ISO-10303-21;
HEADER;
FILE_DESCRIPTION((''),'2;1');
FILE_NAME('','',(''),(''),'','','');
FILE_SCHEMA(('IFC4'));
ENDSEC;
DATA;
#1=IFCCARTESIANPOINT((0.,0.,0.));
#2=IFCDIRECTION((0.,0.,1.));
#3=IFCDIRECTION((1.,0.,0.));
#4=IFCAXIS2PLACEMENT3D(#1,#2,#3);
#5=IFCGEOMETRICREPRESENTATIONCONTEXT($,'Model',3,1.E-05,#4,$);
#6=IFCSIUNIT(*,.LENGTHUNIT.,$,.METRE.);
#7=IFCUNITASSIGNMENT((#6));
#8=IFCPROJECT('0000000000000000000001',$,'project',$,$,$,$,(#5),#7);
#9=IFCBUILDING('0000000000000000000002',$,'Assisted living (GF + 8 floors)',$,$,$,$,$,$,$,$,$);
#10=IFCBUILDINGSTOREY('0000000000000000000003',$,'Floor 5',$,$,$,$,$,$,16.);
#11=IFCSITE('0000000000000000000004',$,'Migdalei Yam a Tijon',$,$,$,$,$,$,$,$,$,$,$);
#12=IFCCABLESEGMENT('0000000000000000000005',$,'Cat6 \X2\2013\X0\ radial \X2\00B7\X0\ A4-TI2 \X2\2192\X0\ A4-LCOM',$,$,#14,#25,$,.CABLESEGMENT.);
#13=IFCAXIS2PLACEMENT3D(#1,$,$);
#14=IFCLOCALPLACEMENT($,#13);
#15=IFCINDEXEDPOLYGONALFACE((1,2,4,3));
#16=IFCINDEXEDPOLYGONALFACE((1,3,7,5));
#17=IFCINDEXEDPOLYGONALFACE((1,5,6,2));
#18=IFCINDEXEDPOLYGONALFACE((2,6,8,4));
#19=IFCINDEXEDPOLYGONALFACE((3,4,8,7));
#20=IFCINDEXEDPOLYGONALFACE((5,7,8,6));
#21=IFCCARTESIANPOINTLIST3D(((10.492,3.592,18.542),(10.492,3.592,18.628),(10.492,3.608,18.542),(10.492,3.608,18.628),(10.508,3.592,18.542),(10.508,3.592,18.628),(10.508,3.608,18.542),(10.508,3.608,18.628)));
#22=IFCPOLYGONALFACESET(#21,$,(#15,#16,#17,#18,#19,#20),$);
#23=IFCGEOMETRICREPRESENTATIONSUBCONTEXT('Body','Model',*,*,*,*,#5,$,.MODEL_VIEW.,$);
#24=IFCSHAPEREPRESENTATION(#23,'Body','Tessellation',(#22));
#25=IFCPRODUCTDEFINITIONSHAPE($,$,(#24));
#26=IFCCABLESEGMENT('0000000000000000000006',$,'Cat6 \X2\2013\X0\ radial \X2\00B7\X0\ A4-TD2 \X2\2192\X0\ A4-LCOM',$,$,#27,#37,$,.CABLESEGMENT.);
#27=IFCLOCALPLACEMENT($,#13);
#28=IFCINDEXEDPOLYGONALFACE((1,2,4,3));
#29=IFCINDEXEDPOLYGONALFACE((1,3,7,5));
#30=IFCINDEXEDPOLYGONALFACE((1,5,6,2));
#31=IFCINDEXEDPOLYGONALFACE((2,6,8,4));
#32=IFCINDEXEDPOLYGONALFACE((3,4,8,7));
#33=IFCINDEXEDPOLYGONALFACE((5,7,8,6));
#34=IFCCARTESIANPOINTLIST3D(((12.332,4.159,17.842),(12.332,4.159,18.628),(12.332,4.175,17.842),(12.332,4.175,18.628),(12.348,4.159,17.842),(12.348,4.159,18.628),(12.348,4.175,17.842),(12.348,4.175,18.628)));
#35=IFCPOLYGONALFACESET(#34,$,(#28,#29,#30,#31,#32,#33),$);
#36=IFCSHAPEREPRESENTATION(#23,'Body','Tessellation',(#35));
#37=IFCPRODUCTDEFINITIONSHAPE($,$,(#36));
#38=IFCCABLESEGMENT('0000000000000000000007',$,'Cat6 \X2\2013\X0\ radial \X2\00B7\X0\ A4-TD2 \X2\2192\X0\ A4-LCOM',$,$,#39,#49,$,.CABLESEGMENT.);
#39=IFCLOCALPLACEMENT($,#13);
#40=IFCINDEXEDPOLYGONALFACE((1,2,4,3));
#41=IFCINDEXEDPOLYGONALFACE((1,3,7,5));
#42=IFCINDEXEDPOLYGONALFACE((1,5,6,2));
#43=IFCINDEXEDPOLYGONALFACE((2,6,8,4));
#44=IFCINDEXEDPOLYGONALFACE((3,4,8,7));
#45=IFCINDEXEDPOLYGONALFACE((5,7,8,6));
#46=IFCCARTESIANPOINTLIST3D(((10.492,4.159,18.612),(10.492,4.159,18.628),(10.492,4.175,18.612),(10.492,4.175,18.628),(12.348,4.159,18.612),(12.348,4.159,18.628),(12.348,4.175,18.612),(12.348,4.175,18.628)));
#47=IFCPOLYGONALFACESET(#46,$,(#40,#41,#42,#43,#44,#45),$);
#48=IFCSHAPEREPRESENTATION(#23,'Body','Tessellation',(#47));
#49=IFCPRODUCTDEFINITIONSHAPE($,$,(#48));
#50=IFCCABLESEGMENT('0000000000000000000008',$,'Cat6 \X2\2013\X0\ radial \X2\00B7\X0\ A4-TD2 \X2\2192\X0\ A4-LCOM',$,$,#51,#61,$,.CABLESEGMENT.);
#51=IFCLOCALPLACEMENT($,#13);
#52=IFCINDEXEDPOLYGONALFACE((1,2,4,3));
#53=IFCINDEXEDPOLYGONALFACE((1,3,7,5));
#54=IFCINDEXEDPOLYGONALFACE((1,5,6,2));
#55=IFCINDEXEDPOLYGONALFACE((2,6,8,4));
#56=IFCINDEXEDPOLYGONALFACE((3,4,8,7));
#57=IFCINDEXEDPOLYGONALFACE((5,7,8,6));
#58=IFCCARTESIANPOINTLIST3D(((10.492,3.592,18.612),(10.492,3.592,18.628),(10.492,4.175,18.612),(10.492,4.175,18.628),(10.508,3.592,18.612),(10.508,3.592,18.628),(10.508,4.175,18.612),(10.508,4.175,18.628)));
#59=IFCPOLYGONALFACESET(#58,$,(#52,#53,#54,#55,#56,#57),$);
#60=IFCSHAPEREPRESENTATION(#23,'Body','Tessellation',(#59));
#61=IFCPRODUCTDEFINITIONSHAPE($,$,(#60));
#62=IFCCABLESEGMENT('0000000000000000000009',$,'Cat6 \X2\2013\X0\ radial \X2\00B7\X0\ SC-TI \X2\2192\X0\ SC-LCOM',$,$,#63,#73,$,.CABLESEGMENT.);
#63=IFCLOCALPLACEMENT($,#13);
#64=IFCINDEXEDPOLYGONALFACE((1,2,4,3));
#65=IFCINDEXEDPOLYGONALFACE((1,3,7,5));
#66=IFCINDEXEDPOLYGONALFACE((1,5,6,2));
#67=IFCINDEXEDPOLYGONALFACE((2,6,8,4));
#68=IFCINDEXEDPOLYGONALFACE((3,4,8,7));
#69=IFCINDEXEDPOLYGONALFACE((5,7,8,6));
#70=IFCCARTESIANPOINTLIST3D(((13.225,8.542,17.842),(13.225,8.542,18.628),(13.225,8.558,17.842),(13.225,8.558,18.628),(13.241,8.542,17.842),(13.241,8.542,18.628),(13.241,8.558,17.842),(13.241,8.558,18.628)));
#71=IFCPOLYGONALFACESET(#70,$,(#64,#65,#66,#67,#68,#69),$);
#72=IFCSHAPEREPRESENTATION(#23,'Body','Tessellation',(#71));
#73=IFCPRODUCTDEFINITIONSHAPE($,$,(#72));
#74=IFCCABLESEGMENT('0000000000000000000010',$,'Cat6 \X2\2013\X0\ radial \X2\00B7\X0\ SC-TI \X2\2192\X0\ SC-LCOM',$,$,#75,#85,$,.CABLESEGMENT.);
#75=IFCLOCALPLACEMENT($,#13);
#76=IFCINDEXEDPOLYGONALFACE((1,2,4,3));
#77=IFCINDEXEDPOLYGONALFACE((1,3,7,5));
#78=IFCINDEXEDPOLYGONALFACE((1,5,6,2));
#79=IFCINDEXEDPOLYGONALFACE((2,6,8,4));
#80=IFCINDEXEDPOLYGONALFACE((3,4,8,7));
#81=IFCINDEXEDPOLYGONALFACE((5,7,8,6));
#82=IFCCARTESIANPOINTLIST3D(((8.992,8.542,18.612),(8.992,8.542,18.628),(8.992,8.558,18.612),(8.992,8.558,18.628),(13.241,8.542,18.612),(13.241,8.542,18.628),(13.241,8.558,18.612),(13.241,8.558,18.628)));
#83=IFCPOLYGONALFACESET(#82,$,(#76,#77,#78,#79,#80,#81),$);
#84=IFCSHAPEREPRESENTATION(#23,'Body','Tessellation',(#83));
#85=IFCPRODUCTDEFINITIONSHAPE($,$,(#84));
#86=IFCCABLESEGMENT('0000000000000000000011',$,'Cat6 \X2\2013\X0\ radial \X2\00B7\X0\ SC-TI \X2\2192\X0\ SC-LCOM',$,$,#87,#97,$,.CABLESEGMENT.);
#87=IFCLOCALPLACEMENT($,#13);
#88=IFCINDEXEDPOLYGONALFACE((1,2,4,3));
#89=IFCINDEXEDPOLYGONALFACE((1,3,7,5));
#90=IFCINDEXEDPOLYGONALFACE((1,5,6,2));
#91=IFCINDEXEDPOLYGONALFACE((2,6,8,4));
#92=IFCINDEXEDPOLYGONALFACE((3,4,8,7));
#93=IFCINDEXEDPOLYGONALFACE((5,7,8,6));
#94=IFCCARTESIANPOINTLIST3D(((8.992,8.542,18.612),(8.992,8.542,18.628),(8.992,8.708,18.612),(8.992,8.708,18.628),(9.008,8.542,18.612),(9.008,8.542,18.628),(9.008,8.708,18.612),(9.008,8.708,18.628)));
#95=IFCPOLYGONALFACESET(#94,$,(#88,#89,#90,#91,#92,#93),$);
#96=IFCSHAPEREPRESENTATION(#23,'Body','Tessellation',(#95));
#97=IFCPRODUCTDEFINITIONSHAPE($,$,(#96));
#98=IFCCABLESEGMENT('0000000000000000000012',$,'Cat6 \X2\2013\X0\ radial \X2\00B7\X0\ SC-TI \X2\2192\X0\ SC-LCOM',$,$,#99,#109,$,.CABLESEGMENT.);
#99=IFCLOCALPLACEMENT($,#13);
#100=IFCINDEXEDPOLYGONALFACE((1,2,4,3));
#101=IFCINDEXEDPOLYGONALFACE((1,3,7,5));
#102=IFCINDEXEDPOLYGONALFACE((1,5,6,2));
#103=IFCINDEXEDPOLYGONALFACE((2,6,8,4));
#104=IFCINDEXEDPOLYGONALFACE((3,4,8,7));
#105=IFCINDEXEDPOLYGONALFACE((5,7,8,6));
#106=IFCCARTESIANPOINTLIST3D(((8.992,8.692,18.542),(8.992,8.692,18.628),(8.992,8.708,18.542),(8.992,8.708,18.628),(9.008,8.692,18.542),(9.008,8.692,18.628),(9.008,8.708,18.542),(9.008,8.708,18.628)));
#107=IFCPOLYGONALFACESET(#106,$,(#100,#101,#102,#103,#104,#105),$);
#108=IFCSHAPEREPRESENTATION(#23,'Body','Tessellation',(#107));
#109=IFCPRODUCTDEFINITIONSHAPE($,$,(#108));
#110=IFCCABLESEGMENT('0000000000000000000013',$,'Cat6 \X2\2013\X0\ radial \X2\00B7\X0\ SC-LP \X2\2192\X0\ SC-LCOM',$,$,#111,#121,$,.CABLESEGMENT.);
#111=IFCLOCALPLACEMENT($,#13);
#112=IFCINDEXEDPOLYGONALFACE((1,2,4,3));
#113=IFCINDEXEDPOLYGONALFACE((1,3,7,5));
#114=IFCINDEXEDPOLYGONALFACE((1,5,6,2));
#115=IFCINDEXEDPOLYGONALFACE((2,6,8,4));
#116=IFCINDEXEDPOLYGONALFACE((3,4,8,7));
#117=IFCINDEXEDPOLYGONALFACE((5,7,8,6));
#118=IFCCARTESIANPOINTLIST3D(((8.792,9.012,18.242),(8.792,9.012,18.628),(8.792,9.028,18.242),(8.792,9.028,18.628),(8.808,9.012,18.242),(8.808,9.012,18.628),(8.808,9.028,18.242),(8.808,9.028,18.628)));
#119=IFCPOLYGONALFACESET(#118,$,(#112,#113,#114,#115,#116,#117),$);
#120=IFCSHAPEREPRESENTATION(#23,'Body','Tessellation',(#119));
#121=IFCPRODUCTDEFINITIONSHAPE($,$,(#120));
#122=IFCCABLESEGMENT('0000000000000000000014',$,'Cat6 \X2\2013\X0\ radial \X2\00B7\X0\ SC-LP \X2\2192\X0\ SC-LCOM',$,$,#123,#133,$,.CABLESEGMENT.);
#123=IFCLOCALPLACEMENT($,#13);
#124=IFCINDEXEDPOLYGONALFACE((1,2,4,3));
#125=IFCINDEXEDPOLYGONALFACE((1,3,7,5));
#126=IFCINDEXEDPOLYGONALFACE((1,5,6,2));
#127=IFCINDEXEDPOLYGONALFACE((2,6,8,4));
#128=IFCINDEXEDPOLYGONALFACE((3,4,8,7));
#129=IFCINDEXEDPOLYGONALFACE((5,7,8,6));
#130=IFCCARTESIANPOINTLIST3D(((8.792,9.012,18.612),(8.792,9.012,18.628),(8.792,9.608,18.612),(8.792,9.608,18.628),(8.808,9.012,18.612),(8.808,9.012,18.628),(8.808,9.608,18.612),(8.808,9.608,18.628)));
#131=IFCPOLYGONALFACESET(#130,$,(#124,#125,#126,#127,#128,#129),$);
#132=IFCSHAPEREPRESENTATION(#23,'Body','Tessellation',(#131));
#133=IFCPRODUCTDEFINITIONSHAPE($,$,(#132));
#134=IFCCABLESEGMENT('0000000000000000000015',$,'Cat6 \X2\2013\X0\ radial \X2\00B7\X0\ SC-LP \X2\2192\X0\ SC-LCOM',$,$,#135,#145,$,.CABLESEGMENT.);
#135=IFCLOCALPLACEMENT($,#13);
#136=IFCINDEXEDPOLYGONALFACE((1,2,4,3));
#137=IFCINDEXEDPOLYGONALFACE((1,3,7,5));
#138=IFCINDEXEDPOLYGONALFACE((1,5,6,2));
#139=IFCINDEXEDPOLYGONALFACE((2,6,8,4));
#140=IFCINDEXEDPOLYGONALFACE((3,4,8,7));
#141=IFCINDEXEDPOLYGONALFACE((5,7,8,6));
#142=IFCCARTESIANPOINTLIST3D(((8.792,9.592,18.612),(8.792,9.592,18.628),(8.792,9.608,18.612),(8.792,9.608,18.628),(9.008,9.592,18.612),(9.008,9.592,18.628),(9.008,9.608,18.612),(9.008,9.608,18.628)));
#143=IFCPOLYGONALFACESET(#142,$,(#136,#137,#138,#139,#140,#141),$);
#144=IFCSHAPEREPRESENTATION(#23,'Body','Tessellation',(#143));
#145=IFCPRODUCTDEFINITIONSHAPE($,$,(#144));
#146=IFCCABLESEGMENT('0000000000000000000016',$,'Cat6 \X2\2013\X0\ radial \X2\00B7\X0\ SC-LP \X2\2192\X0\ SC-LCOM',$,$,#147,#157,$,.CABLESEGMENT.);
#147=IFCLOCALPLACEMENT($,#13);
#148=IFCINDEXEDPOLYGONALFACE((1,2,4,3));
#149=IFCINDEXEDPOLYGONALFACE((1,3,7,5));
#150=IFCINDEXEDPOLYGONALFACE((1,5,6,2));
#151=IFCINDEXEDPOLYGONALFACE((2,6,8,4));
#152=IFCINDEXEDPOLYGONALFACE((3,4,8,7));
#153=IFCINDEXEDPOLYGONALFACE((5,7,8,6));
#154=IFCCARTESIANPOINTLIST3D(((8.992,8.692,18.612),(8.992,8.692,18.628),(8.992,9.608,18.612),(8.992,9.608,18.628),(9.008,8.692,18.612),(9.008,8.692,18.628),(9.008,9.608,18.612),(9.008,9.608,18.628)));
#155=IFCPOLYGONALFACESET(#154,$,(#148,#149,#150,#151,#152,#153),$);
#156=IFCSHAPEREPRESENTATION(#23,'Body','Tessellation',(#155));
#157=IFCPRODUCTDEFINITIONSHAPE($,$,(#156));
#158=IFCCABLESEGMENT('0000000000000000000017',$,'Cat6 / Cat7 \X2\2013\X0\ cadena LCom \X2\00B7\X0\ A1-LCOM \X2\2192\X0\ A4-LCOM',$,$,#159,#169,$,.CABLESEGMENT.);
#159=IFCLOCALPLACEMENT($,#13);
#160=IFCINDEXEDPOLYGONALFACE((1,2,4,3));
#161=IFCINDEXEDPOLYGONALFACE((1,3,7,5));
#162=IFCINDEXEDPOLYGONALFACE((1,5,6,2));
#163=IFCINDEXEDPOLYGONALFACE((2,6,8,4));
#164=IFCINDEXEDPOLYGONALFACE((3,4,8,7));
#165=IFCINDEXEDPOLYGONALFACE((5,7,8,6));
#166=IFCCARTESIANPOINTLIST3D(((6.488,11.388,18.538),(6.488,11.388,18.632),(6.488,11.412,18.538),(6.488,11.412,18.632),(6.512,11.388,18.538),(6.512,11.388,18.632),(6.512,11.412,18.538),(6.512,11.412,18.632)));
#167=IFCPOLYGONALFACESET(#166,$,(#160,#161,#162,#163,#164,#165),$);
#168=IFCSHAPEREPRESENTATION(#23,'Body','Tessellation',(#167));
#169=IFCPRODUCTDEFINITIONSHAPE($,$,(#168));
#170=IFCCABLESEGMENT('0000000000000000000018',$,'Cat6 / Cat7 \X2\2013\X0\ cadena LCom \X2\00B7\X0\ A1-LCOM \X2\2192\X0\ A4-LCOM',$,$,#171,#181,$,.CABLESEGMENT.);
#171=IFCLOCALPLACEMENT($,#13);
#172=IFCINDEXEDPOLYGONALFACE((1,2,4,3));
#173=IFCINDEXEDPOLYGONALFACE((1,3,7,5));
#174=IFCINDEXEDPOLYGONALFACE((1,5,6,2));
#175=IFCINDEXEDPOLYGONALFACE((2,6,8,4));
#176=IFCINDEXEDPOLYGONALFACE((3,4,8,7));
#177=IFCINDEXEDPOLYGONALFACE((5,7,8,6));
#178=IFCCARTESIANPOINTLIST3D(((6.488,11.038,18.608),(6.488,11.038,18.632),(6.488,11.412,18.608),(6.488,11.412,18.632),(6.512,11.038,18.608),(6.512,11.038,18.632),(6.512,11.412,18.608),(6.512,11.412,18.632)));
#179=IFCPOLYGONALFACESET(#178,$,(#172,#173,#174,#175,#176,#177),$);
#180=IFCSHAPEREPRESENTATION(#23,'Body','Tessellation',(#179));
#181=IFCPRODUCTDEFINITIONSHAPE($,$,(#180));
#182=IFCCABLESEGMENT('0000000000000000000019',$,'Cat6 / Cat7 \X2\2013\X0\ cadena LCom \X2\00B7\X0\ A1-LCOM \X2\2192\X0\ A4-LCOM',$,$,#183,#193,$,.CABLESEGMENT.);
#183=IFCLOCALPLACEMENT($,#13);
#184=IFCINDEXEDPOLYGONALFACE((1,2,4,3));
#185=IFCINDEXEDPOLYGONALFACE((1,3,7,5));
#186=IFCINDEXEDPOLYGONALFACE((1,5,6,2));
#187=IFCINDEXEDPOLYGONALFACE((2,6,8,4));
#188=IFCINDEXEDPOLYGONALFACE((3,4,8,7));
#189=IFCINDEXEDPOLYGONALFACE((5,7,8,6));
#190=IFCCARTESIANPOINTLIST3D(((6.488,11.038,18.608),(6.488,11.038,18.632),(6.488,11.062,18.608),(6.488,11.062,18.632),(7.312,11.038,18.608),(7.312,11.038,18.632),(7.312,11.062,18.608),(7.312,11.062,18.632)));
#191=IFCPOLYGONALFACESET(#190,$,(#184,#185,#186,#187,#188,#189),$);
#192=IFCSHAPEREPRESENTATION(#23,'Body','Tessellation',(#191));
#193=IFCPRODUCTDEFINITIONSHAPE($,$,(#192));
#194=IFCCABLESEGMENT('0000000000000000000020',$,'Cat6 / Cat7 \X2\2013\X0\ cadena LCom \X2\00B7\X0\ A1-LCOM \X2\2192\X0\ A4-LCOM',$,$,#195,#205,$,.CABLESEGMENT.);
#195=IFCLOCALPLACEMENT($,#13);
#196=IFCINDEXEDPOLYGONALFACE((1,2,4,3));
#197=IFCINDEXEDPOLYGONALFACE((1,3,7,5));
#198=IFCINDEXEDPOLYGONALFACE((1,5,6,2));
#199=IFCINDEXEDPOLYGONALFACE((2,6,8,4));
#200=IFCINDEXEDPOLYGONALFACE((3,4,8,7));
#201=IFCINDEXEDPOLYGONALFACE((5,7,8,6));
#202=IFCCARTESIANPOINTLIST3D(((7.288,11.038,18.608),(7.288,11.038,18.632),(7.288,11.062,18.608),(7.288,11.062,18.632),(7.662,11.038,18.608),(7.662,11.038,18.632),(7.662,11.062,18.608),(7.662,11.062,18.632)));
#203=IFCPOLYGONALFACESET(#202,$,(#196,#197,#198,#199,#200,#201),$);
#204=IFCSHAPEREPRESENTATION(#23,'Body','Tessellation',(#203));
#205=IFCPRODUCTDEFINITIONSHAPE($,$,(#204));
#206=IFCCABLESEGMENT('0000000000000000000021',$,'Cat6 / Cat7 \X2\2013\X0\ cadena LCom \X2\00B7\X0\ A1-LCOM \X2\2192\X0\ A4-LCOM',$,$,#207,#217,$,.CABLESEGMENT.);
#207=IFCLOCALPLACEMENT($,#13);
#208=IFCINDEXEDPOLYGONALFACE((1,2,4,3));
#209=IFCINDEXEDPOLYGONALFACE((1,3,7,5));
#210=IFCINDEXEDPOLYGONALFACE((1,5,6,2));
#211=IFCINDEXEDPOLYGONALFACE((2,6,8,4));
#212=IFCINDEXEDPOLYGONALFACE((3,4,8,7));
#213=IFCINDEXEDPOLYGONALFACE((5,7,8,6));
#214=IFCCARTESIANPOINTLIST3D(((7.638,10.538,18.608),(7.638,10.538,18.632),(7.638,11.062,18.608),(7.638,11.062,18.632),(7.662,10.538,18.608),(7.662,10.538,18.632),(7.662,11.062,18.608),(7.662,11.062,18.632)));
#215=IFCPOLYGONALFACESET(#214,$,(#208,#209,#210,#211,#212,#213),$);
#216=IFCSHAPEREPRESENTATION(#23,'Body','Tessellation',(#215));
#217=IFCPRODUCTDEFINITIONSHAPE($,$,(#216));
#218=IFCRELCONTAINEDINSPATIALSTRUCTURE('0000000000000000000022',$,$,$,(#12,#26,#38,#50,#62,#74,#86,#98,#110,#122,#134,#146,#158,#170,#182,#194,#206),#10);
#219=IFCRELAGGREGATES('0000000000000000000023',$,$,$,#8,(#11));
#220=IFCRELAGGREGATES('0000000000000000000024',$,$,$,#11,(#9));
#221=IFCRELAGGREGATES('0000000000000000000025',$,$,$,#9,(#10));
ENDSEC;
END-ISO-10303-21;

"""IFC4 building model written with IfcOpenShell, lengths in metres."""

from ifc_helpers import new_model, si_unit, frame, origin_with_axes, context, subcontext, project, spatial, line, indexed_curve, outline, extrude, element, save


model = new_model("IFC4")

# Units and contexts
model_context = context("Model", 3, precision=1e-05, world=origin_with_axes())
body_context = subcontext(model_context, "Body", "Model", "MODEL_VIEW")
ifc_project = project(units=[si_unit("LENGTHUNIT", "METRE")], contexts=[model_context])

# Site, building, storey
site = spatial("IfcSite", under=ifc_project, Name="Migdalei Yam a Tijon")
building = spatial("IfcBuilding", under=site, Name="Assisted living (GF + 8 floors)")
storey = spatial("IfcBuildingStorey", under=building, Name="Floor 5", Elevation=16.0)

# Cable segments
element("IfcCableSegment", 1, inside=storey, Name="Cat6 – radial · A4-TI2 → A4-LCOM", PredefinedType="CABLESEGMENT", context=body_context, shape_type="SweptSolid", body=[
    extrude(outline(indexed_curve([(0.0, 0.0), (0.016, 0.0), (0.016, 0.016), (0.0, 0.016)], segments=[line(1, 2, 3, 4, 1)])), frame((10.492, 3.592, 18.542), z_axis=(0.0, 0.0, 1.0), x_axis=(1.0, 0.0, 0.0)), (0.0, 0.0, 1.0), 0.086),
])
element("IfcCableSegment", 2, inside=storey, Name="Cat6 – radial · A4-TD2 → A4-LCOM", PredefinedType="CABLESEGMENT", context=body_context, shape_type="SweptSolid", body=[
    extrude(outline(indexed_curve([(0.0, 0.0), (0.016, 0.0), (0.016, 0.016), (0.0, 0.016)], segments=[line(1, 2, 3, 4, 1)])), frame((12.332, 4.159, 17.842), z_axis=(0.0, 0.0, 1.0), x_axis=(1.0, 0.0, 0.0)), (0.0, 0.0, 1.0), 0.786),
])
element("IfcCableSegment", 3, inside=storey, Name="Cat6 – radial · A4-TD2 → A4-LCOM", PredefinedType="CABLESEGMENT", context=body_context, shape_type="SweptSolid", body=[
    extrude(outline(indexed_curve([(0.0, 0.0), (1.856, 0.0), (1.856, 0.016), (0.0, 0.016)], segments=[line(1, 2, 3, 4, 1)])), frame((10.492, 4.159, 18.612), z_axis=(0.0, 0.0, 1.0), x_axis=(1.0, 0.0, 0.0)), (0.0, 0.0, 1.0), 0.016),
])
element("IfcCableSegment", 4, inside=storey, Name="Cat6 – radial · A4-TD2 → A4-LCOM", PredefinedType="CABLESEGMENT", context=body_context, shape_type="SweptSolid", body=[
    extrude(outline(indexed_curve([(0.0, 0.0), (0.016, 0.0), (0.016, 0.583), (0.0, 0.583)], segments=[line(1, 2, 3, 4, 1)])), frame((10.492, 3.592, 18.612), z_axis=(0.0, 0.0, 1.0), x_axis=(1.0, 0.0, 0.0)), (0.0, 0.0, 1.0), 0.016),
])
element("IfcCableSegment", 5, inside=storey, Name="Cat6 – radial · SC-TI → SC-LCOM", PredefinedType="CABLESEGMENT", context=body_context, shape_type="SweptSolid", body=[
    extrude(outline(indexed_curve([(0.0, 0.0), (0.016, 0.0), (0.016, 0.016), (0.0, 0.016)], segments=[line(1, 2, 3, 4, 1)])), frame((13.225, 8.542, 17.842), z_axis=(0.0, 0.0, 1.0), x_axis=(1.0, 0.0, 0.0)), (0.0, 0.0, 1.0), 0.786),
])
element("IfcCableSegment", 6, inside=storey, Name="Cat6 – radial · SC-TI → SC-LCOM", PredefinedType="CABLESEGMENT", context=body_context, shape_type="SweptSolid", body=[
    extrude(outline(indexed_curve([(0.0, 0.0), (4.249, 0.0), (4.249, 0.016), (0.0, 0.016)], segments=[line(1, 2, 3, 4, 1)])), frame((8.992, 8.542, 18.612), z_axis=(0.0, 0.0, 1.0), x_axis=(1.0, 0.0, 0.0)), (0.0, 0.0, 1.0), 0.016),
])
element("IfcCableSegment", 7, inside=storey, Name="Cat6 – radial · SC-TI → SC-LCOM", PredefinedType="CABLESEGMENT", context=body_context, shape_type="SweptSolid", body=[
    extrude(outline(indexed_curve([(0.0, 0.0), (0.016, 0.0), (0.016, 0.166), (0.0, 0.166)], segments=[line(1, 2, 3, 4, 1)])), frame((8.992, 8.542, 18.612), z_axis=(0.0, 0.0, 1.0), x_axis=(1.0, 0.0, 0.0)), (0.0, 0.0, 1.0), 0.016),
])
element("IfcCableSegment", 8, inside=storey, Name="Cat6 – radial · SC-TI → SC-LCOM", PredefinedType="CABLESEGMENT", context=body_context, shape_type="SweptSolid", body=[
    extrude(outline(indexed_curve([(0.0, 0.0), (0.016, 0.0), (0.016, 0.016), (0.0, 0.016)], segments=[line(1, 2, 3, 4, 1)])), frame((8.992, 8.692, 18.542), z_axis=(0.0, 0.0, 1.0), x_axis=(1.0, 0.0, 0.0)), (0.0, 0.0, 1.0), 0.086),
])
element("IfcCableSegment", 9, inside=storey, Name="Cat6 – radial · SC-LP → SC-LCOM", PredefinedType="CABLESEGMENT", context=body_context, shape_type="SweptSolid", body=[
    extrude(outline(indexed_curve([(0.0, 0.0), (0.016, 0.0), (0.016, 0.016), (0.0, 0.016)], segments=[line(1, 2, 3, 4, 1)])), frame((8.792, 9.012, 18.242), z_axis=(0.0, 0.0, 1.0), x_axis=(1.0, 0.0, 0.0)), (0.0, 0.0, 1.0), 0.386),
])
element("IfcCableSegment", 10, inside=storey, Name="Cat6 – radial · SC-LP → SC-LCOM", PredefinedType="CABLESEGMENT", context=body_context, shape_type="SweptSolid", body=[
    extrude(outline(indexed_curve([(0.0, 0.0), (0.016, 0.0), (0.016, 0.596), (0.0, 0.596)], segments=[line(1, 2, 3, 4, 1)])), frame((8.792, 9.012, 18.612), z_axis=(0.0, 0.0, 1.0), x_axis=(1.0, 0.0, 0.0)), (0.0, 0.0, 1.0), 0.016),
])
element("IfcCableSegment", 11, inside=storey, Name="Cat6 – radial · SC-LP → SC-LCOM", PredefinedType="CABLESEGMENT", context=body_context, shape_type="SweptSolid", body=[
    extrude(outline(indexed_curve([(0.0, 0.0), (0.216, 0.0), (0.216, 0.016), (0.0, 0.016)], segments=[line(1, 2, 3, 4, 1)])), frame((8.792, 9.592, 18.612), z_axis=(0.0, 0.0, 1.0), x_axis=(1.0, 0.0, 0.0)), (0.0, 0.0, 1.0), 0.016),
])
element("IfcCableSegment", 12, inside=storey, Name="Cat6 – radial · SC-LP → SC-LCOM", PredefinedType="CABLESEGMENT", context=body_context, shape_type="SweptSolid", body=[
    extrude(outline(indexed_curve([(0.0, 0.0), (0.016, 0.0), (0.016, 0.916), (0.0, 0.916)], segments=[line(1, 2, 3, 4, 1)])), frame((8.992, 8.692, 18.612), z_axis=(0.0, 0.0, 1.0), x_axis=(1.0, 0.0, 0.0)), (0.0, 0.0, 1.0), 0.016),
])
element("IfcCableSegment", 13, inside=storey, Name="Cat6 / Cat7 – cadena LCom · A1-LCOM → A4-LCOM", PredefinedType="CABLESEGMENT", context=body_context, shape_type="SweptSolid", body=[
    extrude(outline(indexed_curve([(0.0, 0.0), (0.024, 0.0), (0.024, 0.024), (0.0, 0.024)], segments=[line(1, 2, 3, 4, 1)])), frame((6.488, 11.388, 18.538), z_axis=(0.0, 0.0, 1.0), x_axis=(1.0, 0.0, 0.0)), (0.0, 0.0, 1.0), 0.094),
])
element("IfcCableSegment", 14, inside=storey, Name="Cat6 / Cat7 – cadena LCom · A1-LCOM → A4-LCOM", PredefinedType="CABLESEGMENT", context=body_context, shape_type="SweptSolid", body=[
    extrude(outline(indexed_curve([(0.0, 0.0), (0.024, 0.0), (0.024, 0.374), (0.0, 0.374)], segments=[line(1, 2, 3, 4, 1)])), frame((6.488, 11.038, 18.608), z_axis=(0.0, 0.0, 1.0), x_axis=(1.0, 0.0, 0.0)), (0.0, 0.0, 1.0), 0.024),
])
element("IfcCableSegment", 15, inside=storey, Name="Cat6 / Cat7 – cadena LCom · A1-LCOM → A4-LCOM", PredefinedType="CABLESEGMENT", context=body_context, shape_type="SweptSolid", body=[
    extrude(outline(indexed_curve([(0.0, 0.0), (0.824, 0.0), (0.824, 0.024), (0.0, 0.024)], segments=[line(1, 2, 3, 4, 1)])), frame((6.488, 11.038, 18.608), z_axis=(0.0, 0.0, 1.0), x_axis=(1.0, 0.0, 0.0)), (0.0, 0.0, 1.0), 0.024),
])
element("IfcCableSegment", 16, inside=storey, Name="Cat6 / Cat7 – cadena LCom · A1-LCOM → A4-LCOM", PredefinedType="CABLESEGMENT", context=body_context, shape_type="SweptSolid", body=[
    extrude(outline(indexed_curve([(0.0, 0.0), (0.374, 0.0), (0.374, 0.024), (0.0, 0.024)], segments=[line(1, 2, 3, 4, 1)])), frame((7.288, 11.038, 18.608), z_axis=(0.0, 0.0, 1.0), x_axis=(1.0, 0.0, 0.0)), (0.0, 0.0, 1.0), 0.024),
])
element("IfcCableSegment", 17, inside=storey, Name="Cat6 / Cat7 – cadena LCom · A1-LCOM → A4-LCOM", PredefinedType="CABLESEGMENT", context=body_context, shape_type="SweptSolid", body=[
    extrude(outline(indexed_curve([(0.0, 0.0), (0.024, 0.0), (0.024, 0.524), (0.0, 0.524)], segments=[line(1, 2, 3, 4, 1)])), frame((7.638, 10.538, 18.608), z_axis=(0.0, 0.0, 1.0), x_axis=(1.0, 0.0, 0.0)), (0.0, 0.0, 1.0), 0.024),
])

save(model, "model.ifc")
